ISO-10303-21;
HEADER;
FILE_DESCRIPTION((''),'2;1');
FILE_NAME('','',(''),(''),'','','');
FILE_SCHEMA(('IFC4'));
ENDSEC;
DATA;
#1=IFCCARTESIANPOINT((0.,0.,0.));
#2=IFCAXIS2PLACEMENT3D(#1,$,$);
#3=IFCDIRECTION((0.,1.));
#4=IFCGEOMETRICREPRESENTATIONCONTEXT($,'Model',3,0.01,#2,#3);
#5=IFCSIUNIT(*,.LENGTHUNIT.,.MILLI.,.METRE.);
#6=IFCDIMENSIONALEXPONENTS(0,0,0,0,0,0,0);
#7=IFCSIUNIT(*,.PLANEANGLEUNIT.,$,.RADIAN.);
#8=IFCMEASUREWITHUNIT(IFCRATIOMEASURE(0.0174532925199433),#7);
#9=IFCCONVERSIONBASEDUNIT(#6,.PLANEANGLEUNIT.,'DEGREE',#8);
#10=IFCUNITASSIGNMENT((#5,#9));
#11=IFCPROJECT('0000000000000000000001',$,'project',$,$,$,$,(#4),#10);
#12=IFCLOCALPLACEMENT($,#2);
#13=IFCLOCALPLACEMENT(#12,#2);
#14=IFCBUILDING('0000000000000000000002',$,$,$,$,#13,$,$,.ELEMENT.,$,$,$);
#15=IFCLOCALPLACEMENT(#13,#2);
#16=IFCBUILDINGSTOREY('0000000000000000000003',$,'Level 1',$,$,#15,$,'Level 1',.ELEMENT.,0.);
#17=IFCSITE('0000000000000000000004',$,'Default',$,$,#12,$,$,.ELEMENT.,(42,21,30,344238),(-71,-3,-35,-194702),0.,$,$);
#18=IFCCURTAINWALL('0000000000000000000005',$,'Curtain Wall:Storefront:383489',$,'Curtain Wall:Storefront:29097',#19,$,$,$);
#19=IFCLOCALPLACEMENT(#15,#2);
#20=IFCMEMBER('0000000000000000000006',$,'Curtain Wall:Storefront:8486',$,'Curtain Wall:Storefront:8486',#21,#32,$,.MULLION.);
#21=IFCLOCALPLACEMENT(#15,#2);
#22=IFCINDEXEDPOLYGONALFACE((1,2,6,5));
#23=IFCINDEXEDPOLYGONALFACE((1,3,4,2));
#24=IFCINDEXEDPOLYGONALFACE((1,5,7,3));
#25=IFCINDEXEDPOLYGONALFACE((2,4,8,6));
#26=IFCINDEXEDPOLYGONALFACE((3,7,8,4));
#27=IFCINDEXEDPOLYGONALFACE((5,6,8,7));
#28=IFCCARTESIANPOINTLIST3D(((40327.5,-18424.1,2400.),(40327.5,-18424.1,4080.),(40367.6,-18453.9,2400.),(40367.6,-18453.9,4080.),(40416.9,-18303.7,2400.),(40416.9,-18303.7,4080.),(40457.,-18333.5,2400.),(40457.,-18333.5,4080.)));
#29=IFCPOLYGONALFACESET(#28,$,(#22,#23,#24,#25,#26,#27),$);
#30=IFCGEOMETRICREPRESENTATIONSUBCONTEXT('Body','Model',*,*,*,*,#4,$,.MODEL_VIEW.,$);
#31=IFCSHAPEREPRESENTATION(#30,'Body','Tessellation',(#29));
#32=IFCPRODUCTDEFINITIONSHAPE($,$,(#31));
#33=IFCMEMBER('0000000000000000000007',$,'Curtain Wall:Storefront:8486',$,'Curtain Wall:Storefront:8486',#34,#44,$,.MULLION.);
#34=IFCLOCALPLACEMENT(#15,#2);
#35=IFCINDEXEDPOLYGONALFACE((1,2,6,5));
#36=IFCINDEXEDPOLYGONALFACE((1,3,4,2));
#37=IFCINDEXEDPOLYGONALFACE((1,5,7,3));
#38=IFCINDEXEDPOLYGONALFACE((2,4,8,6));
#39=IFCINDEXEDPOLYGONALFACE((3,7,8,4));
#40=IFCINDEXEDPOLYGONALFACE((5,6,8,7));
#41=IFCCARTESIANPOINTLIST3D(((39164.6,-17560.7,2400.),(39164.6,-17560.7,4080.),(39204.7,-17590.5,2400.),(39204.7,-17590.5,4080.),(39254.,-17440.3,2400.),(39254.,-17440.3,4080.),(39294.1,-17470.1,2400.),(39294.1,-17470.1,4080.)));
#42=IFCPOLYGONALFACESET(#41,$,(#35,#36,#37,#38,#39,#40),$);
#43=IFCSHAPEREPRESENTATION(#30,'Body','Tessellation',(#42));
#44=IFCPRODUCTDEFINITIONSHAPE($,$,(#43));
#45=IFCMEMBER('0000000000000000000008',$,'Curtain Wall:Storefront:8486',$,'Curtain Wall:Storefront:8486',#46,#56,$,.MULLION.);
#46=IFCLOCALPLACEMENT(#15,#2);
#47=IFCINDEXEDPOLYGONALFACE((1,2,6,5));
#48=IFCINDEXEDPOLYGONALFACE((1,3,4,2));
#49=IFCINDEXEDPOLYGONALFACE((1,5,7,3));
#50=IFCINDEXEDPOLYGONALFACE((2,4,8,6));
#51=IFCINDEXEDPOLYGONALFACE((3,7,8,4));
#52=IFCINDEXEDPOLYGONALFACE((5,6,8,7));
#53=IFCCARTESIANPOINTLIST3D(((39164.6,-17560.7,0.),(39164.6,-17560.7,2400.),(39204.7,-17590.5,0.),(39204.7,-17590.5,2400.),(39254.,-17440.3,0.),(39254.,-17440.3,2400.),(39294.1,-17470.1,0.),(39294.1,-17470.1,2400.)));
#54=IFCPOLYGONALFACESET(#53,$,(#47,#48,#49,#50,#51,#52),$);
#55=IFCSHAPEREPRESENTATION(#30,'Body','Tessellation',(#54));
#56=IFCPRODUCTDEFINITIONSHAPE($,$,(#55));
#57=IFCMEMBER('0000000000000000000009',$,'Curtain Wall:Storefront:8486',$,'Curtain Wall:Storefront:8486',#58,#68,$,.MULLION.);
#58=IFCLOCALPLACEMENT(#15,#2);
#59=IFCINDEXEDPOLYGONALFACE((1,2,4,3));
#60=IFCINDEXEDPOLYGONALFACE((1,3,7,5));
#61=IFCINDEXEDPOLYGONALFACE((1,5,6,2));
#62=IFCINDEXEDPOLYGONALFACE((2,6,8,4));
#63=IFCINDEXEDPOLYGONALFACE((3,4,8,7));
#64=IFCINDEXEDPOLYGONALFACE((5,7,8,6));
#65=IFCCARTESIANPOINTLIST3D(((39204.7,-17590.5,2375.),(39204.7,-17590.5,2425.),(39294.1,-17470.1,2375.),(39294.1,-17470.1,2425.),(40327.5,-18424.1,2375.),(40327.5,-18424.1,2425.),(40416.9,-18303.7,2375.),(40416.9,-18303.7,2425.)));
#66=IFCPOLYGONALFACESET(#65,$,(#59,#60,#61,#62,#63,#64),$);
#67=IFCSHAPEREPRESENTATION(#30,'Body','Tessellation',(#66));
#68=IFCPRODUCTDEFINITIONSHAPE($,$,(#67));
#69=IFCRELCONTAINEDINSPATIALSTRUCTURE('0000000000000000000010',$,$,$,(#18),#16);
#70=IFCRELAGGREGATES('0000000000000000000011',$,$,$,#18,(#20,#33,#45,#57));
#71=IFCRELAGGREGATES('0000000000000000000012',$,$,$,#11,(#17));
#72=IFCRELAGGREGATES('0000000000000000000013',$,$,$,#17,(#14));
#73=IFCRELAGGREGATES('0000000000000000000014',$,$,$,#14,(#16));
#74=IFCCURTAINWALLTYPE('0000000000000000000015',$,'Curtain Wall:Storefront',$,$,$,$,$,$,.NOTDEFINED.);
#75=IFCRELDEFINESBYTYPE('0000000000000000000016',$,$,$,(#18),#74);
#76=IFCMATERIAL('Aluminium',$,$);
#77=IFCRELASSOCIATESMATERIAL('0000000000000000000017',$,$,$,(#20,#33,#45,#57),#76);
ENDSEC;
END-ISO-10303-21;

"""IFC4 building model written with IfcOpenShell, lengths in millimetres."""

from ifc_helpers import new_model, entity, si_unit, converted_unit, direction, frame, frame_2d, origin, origin_2d_with_axis, place, context, subcontext, project, spatial, rectangle, extrude, material, type_object, element, aggregate, save


model = new_model("IFC4")

# Units and contexts
model_context = context("Model", 3, precision=0.01, world=origin(), true_north=direction((0.0, 1.0)))
body_context = subcontext(model_context, "Body", "Model", "MODEL_VIEW")
ifc_project = project(units=[si_unit("LENGTHUNIT", "METRE", prefix="MILLI"), converted_unit("PLANEANGLEUNIT", "DEGREE", entity("IfcRatioMeasure", 0.0174532925199433), si_unit("PLANEANGLEUNIT", "RADIAN"), dimensions=[0, 0, 0, 0, 0, 0, 0])], contexts=[model_context])

# Site, building, storey
site_placement = place(None, origin())
site = spatial("IfcSite", under=ifc_project, at=site_placement, Name="Default", CompositionType="ELEMENT", RefLatitude=(42, 21, 30, 344238), RefLongitude=(-71, -3, -35, -194702), RefElevation=0.0)
building_placement = place(site_placement, origin())
building = spatial("IfcBuilding", under=site, at=building_placement, CompositionType="ELEMENT")
storey_placement = place(building_placement, origin())
storey = spatial("IfcBuildingStorey", under=building, at=storey_placement, Name="Level 1", LongName="Level 1", CompositionType="ELEMENT", Elevation=0.0)

# Curtain wall, members
curtain_wall_type = type_object("IfcCurtainWallType", Name="Curtain Wall:Storefront", PredefinedType="NOTDEFINED")
ifc_material = material(Name="Aluminium")
curtain_wall_1_placement = place(storey_placement, origin())
curtain_wall_1 = element("IfcCurtainWall", 1, at=curtain_wall_1_placement, inside=storey, type_object=curtain_wall_type, Name="Curtain Wall:Storefront:383489", ObjectType="Curtain Wall:Storefront:29097")
member_1_placement = place(curtain_wall_1_placement, origin())
member_1 = element("IfcMember", 2, at=member_1_placement, material=ifc_material, Name="Curtain Wall:Storefront:8486", ObjectType="Curtain Wall:Storefront:8486", PredefinedType="MULLION", context=body_context, shape_type="SweptSolid", body=[
    extrude(rectangle(XDim=50.0, YDim=150.0, at=origin_2d_with_axis()), frame((40392.3, -18378.8, 2400.0), z_axis=(0.0, 0.0, 1.0), x_axis=(0.80291, -0.5961, 0.0)), (0.0, 0.0, 1.0), 1680.0),
])
member_2_placement = place(curtain_wall_1_placement, origin())
member_2 = element("IfcMember", 3, at=member_2_placement, material=ifc_material, Name="Curtain Wall:Storefront:8486", ObjectType="Curtain Wall:Storefront:8486", PredefinedType="MULLION", context=body_context, shape_type="SweptSolid", body=[
    extrude(rectangle(XDim=50.0, YDim=150.0, at=frame_2d((0.0, 0.0), x_axis=(1.0, 0.0))), frame((39229.3, -17515.4, 4080.0), z_axis=(0.0, 0.0, -1.0), x_axis=(0.80291, -0.5961, 0.0)), (0.0, 0.0, 1.0), 1680.0),
])
member_3_placement = place(curtain_wall_1_placement, origin())
member_3 = element("IfcMember", 4, at=member_3_placement, material=ifc_material, Name="Curtain Wall:Storefront:8486", ObjectType="Curtain Wall:Storefront:8486", PredefinedType="MULLION", context=body_context, shape_type="SweptSolid", body=[
    extrude(rectangle(XDim=50.0, YDim=150.0, at=frame_2d((0.0, 0.0), x_axis=(1.0, 0.0))), frame((39229.3, -17515.4, 2400.0), z_axis=(0.0, 0.0, -1.0), x_axis=(0.80291, -0.5961, 0.0)), (0.0, 0.0, 1.0), 2400.0),
])
member_4_placement = place(curtain_wall_1_placement, origin())
member_4 = element("IfcMember", 5, at=member_4_placement, material=ifc_material, Name="Curtain Wall:Storefront:8486", ObjectType="Curtain Wall:Storefront:8486", PredefinedType="MULLION", context=body_context, shape_type="SweptSolid", body=[
    extrude(rectangle(XDim=50.0, YDim=150.0, at=origin_2d_with_axis()), frame((40372.2, -18363.9, 2400.0), z_axis=(-0.80291, 0.5961, 0.0), x_axis=(0.0, 0.0, -1.0)), (0.0, 0.0, 1.0), 1398.4),
])
aggregate(curtain_wall_1, [member_1, member_2, member_3, member_4])

save(model, "model.ifc")
